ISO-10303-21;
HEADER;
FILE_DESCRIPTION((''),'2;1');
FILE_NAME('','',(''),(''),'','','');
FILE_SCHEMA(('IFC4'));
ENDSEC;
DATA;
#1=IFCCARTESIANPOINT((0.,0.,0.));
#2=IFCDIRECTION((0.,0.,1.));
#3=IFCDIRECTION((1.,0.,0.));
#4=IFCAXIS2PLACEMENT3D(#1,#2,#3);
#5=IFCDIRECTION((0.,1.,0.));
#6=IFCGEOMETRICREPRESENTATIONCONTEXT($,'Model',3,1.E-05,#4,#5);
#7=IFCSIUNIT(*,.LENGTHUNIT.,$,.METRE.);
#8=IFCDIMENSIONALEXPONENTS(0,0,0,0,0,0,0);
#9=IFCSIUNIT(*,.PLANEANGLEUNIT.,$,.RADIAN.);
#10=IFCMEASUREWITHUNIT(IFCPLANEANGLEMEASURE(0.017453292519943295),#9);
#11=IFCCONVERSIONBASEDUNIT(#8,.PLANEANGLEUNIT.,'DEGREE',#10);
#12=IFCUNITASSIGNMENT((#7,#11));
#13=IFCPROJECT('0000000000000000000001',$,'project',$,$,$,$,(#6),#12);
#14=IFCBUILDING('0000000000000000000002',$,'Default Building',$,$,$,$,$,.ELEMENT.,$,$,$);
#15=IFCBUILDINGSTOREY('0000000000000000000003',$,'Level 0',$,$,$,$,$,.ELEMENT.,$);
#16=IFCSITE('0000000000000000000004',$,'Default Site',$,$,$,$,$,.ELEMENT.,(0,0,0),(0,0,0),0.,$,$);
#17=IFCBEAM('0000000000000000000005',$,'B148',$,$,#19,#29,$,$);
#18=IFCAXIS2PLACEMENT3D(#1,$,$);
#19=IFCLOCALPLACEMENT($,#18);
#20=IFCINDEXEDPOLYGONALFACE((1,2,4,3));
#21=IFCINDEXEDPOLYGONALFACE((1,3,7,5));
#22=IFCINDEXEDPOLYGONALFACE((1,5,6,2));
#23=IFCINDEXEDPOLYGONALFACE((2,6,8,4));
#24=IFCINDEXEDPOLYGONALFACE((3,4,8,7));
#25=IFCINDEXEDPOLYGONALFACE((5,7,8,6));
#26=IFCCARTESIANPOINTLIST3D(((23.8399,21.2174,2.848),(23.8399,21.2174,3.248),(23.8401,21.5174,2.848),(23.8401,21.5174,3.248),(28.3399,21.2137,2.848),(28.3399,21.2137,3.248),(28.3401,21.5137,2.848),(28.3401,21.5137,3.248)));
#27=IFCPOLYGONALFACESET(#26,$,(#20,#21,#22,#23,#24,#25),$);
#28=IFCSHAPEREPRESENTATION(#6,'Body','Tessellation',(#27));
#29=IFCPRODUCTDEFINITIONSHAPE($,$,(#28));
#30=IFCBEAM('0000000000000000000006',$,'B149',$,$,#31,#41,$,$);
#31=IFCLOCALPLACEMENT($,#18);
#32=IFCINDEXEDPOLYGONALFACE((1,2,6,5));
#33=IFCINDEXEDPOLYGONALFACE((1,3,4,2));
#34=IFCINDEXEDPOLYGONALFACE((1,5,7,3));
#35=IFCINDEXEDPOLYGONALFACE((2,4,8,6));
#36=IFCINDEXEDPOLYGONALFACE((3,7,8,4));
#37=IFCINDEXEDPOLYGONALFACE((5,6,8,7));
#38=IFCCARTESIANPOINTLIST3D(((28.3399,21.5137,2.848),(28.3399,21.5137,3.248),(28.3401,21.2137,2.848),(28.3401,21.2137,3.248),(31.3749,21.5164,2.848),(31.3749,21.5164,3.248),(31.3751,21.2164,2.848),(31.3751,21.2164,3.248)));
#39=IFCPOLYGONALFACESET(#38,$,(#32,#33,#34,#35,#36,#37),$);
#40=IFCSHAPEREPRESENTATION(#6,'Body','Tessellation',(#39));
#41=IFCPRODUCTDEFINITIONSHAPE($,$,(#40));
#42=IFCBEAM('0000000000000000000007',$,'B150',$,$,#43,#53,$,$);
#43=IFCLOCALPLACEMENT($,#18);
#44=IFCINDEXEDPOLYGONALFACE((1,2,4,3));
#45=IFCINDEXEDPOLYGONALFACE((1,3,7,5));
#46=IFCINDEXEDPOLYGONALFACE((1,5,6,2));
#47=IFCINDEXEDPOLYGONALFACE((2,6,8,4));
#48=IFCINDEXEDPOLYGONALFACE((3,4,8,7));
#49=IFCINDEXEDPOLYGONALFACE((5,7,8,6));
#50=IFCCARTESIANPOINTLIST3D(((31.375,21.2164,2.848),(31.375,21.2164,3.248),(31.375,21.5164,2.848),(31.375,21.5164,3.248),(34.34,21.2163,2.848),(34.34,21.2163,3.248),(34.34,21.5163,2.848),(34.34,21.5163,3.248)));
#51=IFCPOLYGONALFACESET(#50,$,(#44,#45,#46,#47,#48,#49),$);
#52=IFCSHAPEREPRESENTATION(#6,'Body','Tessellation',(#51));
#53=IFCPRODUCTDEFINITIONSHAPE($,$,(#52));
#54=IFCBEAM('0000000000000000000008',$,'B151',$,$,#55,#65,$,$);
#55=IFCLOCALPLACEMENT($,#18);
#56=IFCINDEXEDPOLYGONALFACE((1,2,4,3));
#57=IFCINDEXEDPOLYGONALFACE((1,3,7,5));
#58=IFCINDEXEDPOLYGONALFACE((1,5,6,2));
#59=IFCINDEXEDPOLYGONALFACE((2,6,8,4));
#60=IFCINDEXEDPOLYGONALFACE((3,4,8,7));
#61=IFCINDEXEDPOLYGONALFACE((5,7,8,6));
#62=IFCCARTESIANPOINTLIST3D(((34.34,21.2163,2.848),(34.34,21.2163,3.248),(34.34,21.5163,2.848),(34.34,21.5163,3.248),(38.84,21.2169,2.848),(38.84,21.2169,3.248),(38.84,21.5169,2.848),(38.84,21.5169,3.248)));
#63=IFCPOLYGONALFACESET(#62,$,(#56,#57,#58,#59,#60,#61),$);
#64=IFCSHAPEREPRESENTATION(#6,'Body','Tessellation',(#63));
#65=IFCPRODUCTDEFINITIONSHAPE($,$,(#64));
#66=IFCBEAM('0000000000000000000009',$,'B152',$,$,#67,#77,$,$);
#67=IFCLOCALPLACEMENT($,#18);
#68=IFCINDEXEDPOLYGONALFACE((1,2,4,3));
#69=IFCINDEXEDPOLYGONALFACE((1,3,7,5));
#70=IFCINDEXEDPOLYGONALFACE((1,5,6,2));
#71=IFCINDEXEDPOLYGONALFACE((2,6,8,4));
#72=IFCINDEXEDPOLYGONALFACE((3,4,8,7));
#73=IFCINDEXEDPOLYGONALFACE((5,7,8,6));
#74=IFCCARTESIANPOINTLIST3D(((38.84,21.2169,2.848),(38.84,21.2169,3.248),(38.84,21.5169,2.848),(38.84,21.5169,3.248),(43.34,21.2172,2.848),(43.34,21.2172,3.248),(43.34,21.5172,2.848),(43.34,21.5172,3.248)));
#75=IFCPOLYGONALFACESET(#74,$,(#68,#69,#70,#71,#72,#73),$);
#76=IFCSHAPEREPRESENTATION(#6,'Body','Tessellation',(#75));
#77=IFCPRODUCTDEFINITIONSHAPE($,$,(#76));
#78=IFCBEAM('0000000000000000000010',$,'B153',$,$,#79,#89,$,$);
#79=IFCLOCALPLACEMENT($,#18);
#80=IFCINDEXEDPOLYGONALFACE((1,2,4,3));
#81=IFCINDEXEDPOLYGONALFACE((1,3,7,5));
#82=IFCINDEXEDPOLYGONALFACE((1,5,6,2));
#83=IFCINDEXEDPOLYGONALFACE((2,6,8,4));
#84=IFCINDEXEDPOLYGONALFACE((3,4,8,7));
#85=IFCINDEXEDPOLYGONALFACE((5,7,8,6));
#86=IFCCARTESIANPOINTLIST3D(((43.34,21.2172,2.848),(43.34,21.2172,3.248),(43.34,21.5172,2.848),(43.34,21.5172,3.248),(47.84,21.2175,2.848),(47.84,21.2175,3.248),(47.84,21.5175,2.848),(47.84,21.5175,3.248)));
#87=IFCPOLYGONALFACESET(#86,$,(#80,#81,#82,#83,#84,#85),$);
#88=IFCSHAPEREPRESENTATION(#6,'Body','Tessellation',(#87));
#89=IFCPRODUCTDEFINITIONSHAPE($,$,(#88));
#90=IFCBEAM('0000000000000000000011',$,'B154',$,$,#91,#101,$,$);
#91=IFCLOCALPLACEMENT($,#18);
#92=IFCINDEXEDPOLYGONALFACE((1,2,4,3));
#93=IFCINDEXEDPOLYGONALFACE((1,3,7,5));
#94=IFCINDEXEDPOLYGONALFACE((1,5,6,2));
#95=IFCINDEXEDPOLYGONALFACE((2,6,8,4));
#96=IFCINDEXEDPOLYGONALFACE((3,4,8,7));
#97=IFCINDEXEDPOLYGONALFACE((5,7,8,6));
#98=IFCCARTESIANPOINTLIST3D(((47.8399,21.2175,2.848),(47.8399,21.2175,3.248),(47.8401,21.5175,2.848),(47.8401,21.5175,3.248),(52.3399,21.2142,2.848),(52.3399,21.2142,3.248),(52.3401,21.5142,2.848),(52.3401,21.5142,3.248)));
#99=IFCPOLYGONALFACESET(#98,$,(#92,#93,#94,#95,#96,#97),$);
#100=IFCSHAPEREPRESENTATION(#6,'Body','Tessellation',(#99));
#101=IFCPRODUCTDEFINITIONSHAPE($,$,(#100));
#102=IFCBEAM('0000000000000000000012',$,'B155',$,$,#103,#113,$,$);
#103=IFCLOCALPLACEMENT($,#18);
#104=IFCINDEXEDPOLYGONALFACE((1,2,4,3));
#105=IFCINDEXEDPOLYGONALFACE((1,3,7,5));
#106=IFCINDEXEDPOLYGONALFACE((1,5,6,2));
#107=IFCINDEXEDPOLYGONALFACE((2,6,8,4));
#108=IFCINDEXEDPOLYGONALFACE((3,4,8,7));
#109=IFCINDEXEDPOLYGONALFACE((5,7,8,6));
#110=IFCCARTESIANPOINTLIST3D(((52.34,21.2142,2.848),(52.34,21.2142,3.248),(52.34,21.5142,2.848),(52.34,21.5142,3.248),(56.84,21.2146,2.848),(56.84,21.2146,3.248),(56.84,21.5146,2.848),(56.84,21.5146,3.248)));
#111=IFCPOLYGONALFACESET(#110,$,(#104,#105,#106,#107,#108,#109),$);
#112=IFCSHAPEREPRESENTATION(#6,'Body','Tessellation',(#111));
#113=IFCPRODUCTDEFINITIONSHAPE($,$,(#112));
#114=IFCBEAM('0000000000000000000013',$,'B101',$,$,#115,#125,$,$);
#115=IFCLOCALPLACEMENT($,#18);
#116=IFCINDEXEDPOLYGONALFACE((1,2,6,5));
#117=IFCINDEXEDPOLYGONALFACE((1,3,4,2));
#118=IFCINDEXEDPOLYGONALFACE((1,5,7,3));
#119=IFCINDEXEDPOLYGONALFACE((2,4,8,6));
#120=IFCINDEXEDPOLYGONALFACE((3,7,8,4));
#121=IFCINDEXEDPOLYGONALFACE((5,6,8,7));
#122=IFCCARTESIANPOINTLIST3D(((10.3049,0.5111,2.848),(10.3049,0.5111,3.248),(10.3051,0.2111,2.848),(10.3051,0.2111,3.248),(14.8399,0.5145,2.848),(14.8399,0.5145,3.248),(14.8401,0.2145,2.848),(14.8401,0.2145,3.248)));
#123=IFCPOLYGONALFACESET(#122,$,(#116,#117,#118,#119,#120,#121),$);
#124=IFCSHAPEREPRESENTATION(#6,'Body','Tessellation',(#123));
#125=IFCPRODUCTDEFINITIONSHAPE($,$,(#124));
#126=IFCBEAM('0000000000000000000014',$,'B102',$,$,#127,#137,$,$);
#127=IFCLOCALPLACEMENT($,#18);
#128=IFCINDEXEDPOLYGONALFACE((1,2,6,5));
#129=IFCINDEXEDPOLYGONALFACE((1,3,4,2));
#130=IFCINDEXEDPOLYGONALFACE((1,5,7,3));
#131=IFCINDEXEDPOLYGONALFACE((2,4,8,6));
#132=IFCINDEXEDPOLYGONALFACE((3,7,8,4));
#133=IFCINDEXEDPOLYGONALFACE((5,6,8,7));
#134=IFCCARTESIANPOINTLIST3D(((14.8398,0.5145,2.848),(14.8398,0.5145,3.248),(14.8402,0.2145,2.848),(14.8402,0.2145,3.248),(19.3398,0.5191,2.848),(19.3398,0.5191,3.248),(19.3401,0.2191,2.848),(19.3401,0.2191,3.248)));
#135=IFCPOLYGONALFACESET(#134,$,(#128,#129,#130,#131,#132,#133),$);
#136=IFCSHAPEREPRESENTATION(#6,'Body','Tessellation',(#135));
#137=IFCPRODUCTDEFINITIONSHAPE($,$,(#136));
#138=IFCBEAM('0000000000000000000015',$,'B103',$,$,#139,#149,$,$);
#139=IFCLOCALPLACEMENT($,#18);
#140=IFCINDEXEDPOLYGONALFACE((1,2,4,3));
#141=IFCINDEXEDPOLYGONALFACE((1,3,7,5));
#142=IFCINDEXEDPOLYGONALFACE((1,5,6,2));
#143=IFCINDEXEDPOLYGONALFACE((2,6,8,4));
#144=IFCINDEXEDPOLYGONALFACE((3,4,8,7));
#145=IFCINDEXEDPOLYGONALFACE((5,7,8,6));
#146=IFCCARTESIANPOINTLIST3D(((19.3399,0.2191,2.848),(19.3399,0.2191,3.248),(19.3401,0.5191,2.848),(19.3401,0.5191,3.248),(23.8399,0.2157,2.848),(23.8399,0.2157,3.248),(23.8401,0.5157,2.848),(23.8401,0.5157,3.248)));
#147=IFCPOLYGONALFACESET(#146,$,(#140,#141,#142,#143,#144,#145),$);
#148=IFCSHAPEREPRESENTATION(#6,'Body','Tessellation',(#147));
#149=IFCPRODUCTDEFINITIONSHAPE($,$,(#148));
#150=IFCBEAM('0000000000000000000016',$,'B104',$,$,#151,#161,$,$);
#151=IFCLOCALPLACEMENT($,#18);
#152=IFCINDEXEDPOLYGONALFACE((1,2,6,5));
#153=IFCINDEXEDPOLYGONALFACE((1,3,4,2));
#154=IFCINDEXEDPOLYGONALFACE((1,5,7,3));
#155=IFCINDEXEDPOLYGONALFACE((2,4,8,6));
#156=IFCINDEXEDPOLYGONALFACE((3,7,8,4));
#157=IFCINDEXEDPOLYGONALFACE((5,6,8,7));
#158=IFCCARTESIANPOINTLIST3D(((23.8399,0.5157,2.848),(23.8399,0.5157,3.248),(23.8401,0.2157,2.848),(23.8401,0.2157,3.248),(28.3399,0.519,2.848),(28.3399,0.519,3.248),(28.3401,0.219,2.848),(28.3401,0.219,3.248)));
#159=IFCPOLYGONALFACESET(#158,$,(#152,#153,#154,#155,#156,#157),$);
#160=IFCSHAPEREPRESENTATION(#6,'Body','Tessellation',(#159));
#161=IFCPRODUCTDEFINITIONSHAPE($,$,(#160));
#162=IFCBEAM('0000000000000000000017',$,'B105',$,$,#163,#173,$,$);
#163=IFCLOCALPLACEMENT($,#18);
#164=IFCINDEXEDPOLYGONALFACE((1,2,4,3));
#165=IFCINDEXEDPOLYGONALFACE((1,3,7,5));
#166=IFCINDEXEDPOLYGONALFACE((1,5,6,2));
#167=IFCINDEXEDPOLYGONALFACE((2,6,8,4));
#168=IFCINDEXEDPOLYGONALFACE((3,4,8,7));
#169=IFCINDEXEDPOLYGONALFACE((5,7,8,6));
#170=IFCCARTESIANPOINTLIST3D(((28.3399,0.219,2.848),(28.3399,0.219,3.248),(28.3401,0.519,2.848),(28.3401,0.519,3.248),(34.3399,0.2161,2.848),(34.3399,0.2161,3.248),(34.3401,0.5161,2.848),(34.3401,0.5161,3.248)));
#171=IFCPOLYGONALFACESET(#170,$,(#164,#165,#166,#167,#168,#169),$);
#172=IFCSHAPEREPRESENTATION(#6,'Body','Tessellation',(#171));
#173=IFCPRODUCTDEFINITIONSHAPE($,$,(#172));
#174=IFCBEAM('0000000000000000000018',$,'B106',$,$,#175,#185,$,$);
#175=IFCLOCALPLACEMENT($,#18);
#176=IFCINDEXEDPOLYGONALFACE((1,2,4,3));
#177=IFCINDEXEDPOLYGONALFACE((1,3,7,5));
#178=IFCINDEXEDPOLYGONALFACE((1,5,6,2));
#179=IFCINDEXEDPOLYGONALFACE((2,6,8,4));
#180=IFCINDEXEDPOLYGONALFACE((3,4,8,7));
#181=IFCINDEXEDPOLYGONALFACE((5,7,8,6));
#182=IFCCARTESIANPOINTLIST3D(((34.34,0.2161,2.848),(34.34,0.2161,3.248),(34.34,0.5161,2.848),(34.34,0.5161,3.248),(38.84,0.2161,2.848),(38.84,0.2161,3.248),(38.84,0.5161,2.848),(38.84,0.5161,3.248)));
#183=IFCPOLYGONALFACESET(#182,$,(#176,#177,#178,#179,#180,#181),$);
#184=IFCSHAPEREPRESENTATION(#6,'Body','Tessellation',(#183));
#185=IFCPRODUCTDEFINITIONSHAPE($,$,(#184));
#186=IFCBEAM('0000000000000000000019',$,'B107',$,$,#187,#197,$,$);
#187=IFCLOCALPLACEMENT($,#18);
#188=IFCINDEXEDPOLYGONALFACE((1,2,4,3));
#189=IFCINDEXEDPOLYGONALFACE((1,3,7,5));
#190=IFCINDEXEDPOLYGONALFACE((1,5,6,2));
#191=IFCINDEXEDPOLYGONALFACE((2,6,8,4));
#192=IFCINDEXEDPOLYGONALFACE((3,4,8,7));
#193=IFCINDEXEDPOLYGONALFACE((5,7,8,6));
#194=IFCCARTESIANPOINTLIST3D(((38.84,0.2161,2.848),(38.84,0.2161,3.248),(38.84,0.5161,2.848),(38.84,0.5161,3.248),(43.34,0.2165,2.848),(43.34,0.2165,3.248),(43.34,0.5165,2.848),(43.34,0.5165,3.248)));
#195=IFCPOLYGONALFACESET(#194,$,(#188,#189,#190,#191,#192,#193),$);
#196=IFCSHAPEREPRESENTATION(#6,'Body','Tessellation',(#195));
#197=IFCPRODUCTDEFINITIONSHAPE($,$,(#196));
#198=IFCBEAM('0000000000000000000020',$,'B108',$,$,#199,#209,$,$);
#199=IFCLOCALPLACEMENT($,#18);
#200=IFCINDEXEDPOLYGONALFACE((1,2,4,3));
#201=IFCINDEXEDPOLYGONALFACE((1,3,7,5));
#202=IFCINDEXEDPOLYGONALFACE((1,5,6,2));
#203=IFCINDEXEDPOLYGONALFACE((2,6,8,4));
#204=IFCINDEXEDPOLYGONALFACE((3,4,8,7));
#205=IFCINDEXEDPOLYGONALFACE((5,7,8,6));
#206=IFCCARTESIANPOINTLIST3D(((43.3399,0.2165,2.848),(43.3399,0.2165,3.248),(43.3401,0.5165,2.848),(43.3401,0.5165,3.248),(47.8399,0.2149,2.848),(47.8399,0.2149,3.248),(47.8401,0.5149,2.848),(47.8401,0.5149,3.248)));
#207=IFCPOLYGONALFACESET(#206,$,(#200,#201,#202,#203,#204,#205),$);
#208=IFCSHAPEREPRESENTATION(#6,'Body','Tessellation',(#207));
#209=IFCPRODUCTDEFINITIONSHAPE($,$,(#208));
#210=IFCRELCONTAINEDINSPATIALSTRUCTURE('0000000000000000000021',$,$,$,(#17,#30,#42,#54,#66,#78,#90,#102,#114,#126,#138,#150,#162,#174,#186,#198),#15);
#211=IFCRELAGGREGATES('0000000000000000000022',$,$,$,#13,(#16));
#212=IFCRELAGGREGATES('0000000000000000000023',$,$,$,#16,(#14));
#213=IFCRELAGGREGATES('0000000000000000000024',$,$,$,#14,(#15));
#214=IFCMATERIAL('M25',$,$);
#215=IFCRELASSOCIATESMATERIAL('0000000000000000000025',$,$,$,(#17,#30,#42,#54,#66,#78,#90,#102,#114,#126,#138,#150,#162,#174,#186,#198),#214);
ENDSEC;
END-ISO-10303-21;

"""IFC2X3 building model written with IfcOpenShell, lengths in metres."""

from ifc_helpers import new_model, entity, si_unit, converted_unit, direction, frame, frame_2d, origin_with_axes, place, context, project, spatial, rectangle, extrude, material, element, save


model = new_model("IFC2X3")

# Units and contexts
model_context = context("Model", 3, precision=1e-05, world=origin_with_axes(), true_north=direction((0.0, 1.0, 0.0)))
ifc_project = project(units=[si_unit("LENGTHUNIT", "METRE"), converted_unit("PLANEANGLEUNIT", "DEGREE", entity("IfcPlaneAngleMeasure", 0.017453292519943295), si_unit("PLANEANGLEUNIT", "RADIAN"), dimensions=[0, 0, 0, 0, 0, 0, 0])], contexts=[model_context])

# Site, building, storey
site = spatial("IfcSite", under=ifc_project, Name="Default Site", CompositionType="ELEMENT", RefLatitude=(0, 0, 0), RefLongitude=(0, 0, 0), RefElevation=0.0)
building = spatial("IfcBuilding", under=site, Name="Default Building", CompositionType="ELEMENT")
storey = spatial("IfcBuildingStorey", under=building, Name="Level 0", CompositionType="ELEMENT")

# Shared definitions
ifc_material = material(Name="M25")
placement = place(None, origin_with_axes())

# Beams
element("IfcBeam", 1, at=placement, inside=storey, material=ifc_material, Name="B148", context=model_context, shape_type="SweptSolid", body=[
    extrude(rectangle(XDim=0.3, YDim=0.4, at=frame_2d((0.0, 0.0), x_axis=(0.0, 1.0, 0.0))), frame((23.84, 21.3674, 3.048), z_axis=(1.0, -0.000812, 0.0), x_axis=(0.0, 0.0, -1.0)), (0.0, 0.0, 1.0), 4.5),
])
element("IfcBeam", 2, at=placement, inside=storey, material=ifc_material, Name="B149", context=model_context, shape_type="SweptSolid", body=[
    extrude(rectangle(XDim=0.3, YDim=0.4, at=frame_2d((0.0, 0.0), x_axis=(0.0, 1.0, 0.0))), frame((28.34, 21.3637, 3.048), z_axis=(1.0, 0.000883, 0.0), x_axis=(0.0, 0.0, -1.0)), (0.0, 0.0, 1.0), 3.035),
])
element("IfcBeam", 3, at=placement, inside=storey, material=ifc_material, Name="B150", context=model_context, shape_type="SweptSolid", body=[
    extrude(rectangle(XDim=0.3, YDim=0.4, at=frame_2d((0.0, 0.0), x_axis=(0.0, 1.0, 0.0))), frame((31.375, 21.3664, 3.048), z_axis=(1.0, -0.000016, 0.0), x_axis=(0.0, 0.0, -1.0)), (0.0, 0.0, 1.0), 2.965),
])
element("IfcBeam", 4, at=placement, inside=storey, material=ifc_material, Name="B151", context=model_context, shape_type="SweptSolid", body=[
    extrude(rectangle(XDim=0.3, YDim=0.4, at=frame_2d((0.0, 0.0), x_axis=(0.0, 1.0, 0.0))), frame((34.34, 21.3663, 3.048), z_axis=(1.0, 0.000136, 0.0), x_axis=(0.0, 0.0, -1.0)), (0.0, 0.0, 1.0), 4.5),
])
element("IfcBeam", 5, at=placement, inside=storey, material=ifc_material, Name="B152", context=model_context, shape_type="SweptSolid", body=[
    extrude(rectangle(XDim=0.3, YDim=0.4, at=frame_2d((0.0, 0.0), x_axis=(0.0, 1.0, 0.0))), frame((38.84, 21.3669, 3.048), z_axis=(1.0, 0.00005, 0.0), x_axis=(0.0, 0.0, -1.0)), (0.0, 0.0, 1.0), 4.5),
])
element("IfcBeam", 6, at=placement, inside=storey, material=ifc_material, Name="B153", context=model_context, shape_type="SweptSolid", body=[
    extrude(rectangle(XDim=0.3, YDim=0.4, at=frame_2d((0.0, 0.0), x_axis=(0.0, 1.0, 0.0))), frame((43.34, 21.3672, 3.048), z_axis=(1.0, 0.000075, 0.0), x_axis=(0.0, 0.0, -1.0)), (0.0, 0.0, 1.0), 4.5),
])
element("IfcBeam", 7, at=placement, inside=storey, material=ifc_material, Name="B154", context=model_context, shape_type="SweptSolid", body=[
    extrude(rectangle(XDim=0.3, YDim=0.4, at=frame_2d((0.0, 0.0), x_axis=(0.0, 1.0, 0.0))), frame((47.84, 21.3675, 3.048), z_axis=(1.0, -0.000744, 0.0), x_axis=(0.0, 0.0, -1.0)), (0.0, 0.0, 1.0), 4.5),
])
element("IfcBeam", 8, at=placement, inside=storey, material=ifc_material, Name="B155", context=model_context, shape_type="SweptSolid", body=[
    extrude(rectangle(XDim=0.3, YDim=0.4, at=frame_2d((0.0, 0.0), x_axis=(0.0, 1.0, 0.0))), frame((52.34, 21.3642, 3.048), z_axis=(1.0, 0.000102, 0.0), x_axis=(0.0, 0.0, -1.0)), (0.0, 0.0, 1.0), 4.5),
])
element("IfcBeam", 9, at=placement, inside=storey, material=ifc_material, Name="B101", context=model_context, shape_type="SweptSolid", body=[
    extrude(rectangle(XDim=0.3, YDim=0.4, at=frame_2d((0.0, 0.0), x_axis=(0.0, 1.0, 0.0))), frame((10.305, 0.3611, 3.048), z_axis=(1.0, 0.000762, 0.0), x_axis=(0.0, 0.0, -1.0)), (0.0, 0.0, 1.0), 4.535),
])
element("IfcBeam", 10, at=placement, inside=storey, material=ifc_material, Name="B102", context=model_context, shape_type="SweptSolid", body=[
    extrude(rectangle(XDim=0.3, YDim=0.4, at=frame_2d((0.0, 0.0), x_axis=(0.0, 1.0, 0.0))), frame((14.84, 0.3645, 3.048), z_axis=(0.999999, 0.00101, 0.0), x_axis=(0.0, 0.0, -1.0)), (0.0, 0.0, 1.0), 4.5),
])
element("IfcBeam", 11, at=placement, inside=storey, material=ifc_material, Name="B103", context=model_context, shape_type="SweptSolid", body=[
    extrude(rectangle(XDim=0.3, YDim=0.4, at=frame_2d((0.0, 0.0), x_axis=(0.0, 1.0, 0.0))), frame((19.34, 0.3691, 3.048), z_axis=(1.0, -0.000757, 0.0), x_axis=(0.0, 0.0, -1.0)), (0.0, 0.0, 1.0), 4.5),
])
element("IfcBeam", 12, at=placement, inside=storey, material=ifc_material, Name="B104", context=model_context, shape_type="SweptSolid", body=[
    extrude(rectangle(XDim=0.3, YDim=0.4, at=frame_2d((0.0, 0.0), x_axis=(0.0, 1.0, 0.0))), frame((23.84, 0.3657, 3.048), z_axis=(1.0, 0.00075, 0.0), x_axis=(0.0, 0.0, -1.0)), (0.0, 0.0, 1.0), 4.5),
])
element("IfcBeam", 13, at=placement, inside=storey, material=ifc_material, Name="B105", context=model_context, shape_type="SweptSolid", body=[
    extrude(rectangle(XDim=0.3, YDim=0.4, at=frame_2d((0.0, 0.0), x_axis=(0.0, 1.0, 0.0))), frame((28.34, 0.369, 3.048), z_axis=(1.0, -0.000487, 0.0), x_axis=(0.0, 0.0, -1.0)), (0.0, 0.0, 1.0), 6.0),
])
element("IfcBeam", 14, at=placement, inside=storey, material=ifc_material, Name="B106", context=model_context, shape_type="SweptSolid", body=[
    extrude(rectangle(XDim=0.3, YDim=0.4, at=frame_2d((0.0, 0.0), x_axis=(0.0, 1.0, 0.0))), frame((34.34, 0.3661, 3.048), z_axis=(1.0, 0.000003, 0.0), x_axis=(0.0, 0.0, -1.0)), (0.0, 0.0, 1.0), 4.5),
])
element("IfcBeam", 15, at=placement, inside=storey, material=ifc_material, Name="B107", context=model_context, shape_type="SweptSolid", body=[
    extrude(rectangle(XDim=0.3, YDim=0.4, at=frame_2d((0.0, 0.0), x_axis=(0.0, 1.0, 0.0))), frame((38.84, 0.3661, 3.048), z_axis=(1.0, 0.000077, 0.0), x_axis=(0.0, 0.0, -1.0)), (0.0, 0.0, 1.0), 4.5),
])
element("IfcBeam", 16, at=placement, inside=storey, material=ifc_material, Name="B108", context=model_context, shape_type="SweptSolid", body=[
    extrude(rectangle(XDim=0.3, YDim=0.4, at=frame_2d((0.0, 0.0), x_axis=(0.0, 1.0, 0.0))), frame((43.34, 0.3665, 3.048), z_axis=(1.0, -0.000358, 0.0), x_axis=(0.0, 0.0, -1.0)), (0.0, 0.0, 1.0), 4.5),
])

save(model, "model.ifc")
